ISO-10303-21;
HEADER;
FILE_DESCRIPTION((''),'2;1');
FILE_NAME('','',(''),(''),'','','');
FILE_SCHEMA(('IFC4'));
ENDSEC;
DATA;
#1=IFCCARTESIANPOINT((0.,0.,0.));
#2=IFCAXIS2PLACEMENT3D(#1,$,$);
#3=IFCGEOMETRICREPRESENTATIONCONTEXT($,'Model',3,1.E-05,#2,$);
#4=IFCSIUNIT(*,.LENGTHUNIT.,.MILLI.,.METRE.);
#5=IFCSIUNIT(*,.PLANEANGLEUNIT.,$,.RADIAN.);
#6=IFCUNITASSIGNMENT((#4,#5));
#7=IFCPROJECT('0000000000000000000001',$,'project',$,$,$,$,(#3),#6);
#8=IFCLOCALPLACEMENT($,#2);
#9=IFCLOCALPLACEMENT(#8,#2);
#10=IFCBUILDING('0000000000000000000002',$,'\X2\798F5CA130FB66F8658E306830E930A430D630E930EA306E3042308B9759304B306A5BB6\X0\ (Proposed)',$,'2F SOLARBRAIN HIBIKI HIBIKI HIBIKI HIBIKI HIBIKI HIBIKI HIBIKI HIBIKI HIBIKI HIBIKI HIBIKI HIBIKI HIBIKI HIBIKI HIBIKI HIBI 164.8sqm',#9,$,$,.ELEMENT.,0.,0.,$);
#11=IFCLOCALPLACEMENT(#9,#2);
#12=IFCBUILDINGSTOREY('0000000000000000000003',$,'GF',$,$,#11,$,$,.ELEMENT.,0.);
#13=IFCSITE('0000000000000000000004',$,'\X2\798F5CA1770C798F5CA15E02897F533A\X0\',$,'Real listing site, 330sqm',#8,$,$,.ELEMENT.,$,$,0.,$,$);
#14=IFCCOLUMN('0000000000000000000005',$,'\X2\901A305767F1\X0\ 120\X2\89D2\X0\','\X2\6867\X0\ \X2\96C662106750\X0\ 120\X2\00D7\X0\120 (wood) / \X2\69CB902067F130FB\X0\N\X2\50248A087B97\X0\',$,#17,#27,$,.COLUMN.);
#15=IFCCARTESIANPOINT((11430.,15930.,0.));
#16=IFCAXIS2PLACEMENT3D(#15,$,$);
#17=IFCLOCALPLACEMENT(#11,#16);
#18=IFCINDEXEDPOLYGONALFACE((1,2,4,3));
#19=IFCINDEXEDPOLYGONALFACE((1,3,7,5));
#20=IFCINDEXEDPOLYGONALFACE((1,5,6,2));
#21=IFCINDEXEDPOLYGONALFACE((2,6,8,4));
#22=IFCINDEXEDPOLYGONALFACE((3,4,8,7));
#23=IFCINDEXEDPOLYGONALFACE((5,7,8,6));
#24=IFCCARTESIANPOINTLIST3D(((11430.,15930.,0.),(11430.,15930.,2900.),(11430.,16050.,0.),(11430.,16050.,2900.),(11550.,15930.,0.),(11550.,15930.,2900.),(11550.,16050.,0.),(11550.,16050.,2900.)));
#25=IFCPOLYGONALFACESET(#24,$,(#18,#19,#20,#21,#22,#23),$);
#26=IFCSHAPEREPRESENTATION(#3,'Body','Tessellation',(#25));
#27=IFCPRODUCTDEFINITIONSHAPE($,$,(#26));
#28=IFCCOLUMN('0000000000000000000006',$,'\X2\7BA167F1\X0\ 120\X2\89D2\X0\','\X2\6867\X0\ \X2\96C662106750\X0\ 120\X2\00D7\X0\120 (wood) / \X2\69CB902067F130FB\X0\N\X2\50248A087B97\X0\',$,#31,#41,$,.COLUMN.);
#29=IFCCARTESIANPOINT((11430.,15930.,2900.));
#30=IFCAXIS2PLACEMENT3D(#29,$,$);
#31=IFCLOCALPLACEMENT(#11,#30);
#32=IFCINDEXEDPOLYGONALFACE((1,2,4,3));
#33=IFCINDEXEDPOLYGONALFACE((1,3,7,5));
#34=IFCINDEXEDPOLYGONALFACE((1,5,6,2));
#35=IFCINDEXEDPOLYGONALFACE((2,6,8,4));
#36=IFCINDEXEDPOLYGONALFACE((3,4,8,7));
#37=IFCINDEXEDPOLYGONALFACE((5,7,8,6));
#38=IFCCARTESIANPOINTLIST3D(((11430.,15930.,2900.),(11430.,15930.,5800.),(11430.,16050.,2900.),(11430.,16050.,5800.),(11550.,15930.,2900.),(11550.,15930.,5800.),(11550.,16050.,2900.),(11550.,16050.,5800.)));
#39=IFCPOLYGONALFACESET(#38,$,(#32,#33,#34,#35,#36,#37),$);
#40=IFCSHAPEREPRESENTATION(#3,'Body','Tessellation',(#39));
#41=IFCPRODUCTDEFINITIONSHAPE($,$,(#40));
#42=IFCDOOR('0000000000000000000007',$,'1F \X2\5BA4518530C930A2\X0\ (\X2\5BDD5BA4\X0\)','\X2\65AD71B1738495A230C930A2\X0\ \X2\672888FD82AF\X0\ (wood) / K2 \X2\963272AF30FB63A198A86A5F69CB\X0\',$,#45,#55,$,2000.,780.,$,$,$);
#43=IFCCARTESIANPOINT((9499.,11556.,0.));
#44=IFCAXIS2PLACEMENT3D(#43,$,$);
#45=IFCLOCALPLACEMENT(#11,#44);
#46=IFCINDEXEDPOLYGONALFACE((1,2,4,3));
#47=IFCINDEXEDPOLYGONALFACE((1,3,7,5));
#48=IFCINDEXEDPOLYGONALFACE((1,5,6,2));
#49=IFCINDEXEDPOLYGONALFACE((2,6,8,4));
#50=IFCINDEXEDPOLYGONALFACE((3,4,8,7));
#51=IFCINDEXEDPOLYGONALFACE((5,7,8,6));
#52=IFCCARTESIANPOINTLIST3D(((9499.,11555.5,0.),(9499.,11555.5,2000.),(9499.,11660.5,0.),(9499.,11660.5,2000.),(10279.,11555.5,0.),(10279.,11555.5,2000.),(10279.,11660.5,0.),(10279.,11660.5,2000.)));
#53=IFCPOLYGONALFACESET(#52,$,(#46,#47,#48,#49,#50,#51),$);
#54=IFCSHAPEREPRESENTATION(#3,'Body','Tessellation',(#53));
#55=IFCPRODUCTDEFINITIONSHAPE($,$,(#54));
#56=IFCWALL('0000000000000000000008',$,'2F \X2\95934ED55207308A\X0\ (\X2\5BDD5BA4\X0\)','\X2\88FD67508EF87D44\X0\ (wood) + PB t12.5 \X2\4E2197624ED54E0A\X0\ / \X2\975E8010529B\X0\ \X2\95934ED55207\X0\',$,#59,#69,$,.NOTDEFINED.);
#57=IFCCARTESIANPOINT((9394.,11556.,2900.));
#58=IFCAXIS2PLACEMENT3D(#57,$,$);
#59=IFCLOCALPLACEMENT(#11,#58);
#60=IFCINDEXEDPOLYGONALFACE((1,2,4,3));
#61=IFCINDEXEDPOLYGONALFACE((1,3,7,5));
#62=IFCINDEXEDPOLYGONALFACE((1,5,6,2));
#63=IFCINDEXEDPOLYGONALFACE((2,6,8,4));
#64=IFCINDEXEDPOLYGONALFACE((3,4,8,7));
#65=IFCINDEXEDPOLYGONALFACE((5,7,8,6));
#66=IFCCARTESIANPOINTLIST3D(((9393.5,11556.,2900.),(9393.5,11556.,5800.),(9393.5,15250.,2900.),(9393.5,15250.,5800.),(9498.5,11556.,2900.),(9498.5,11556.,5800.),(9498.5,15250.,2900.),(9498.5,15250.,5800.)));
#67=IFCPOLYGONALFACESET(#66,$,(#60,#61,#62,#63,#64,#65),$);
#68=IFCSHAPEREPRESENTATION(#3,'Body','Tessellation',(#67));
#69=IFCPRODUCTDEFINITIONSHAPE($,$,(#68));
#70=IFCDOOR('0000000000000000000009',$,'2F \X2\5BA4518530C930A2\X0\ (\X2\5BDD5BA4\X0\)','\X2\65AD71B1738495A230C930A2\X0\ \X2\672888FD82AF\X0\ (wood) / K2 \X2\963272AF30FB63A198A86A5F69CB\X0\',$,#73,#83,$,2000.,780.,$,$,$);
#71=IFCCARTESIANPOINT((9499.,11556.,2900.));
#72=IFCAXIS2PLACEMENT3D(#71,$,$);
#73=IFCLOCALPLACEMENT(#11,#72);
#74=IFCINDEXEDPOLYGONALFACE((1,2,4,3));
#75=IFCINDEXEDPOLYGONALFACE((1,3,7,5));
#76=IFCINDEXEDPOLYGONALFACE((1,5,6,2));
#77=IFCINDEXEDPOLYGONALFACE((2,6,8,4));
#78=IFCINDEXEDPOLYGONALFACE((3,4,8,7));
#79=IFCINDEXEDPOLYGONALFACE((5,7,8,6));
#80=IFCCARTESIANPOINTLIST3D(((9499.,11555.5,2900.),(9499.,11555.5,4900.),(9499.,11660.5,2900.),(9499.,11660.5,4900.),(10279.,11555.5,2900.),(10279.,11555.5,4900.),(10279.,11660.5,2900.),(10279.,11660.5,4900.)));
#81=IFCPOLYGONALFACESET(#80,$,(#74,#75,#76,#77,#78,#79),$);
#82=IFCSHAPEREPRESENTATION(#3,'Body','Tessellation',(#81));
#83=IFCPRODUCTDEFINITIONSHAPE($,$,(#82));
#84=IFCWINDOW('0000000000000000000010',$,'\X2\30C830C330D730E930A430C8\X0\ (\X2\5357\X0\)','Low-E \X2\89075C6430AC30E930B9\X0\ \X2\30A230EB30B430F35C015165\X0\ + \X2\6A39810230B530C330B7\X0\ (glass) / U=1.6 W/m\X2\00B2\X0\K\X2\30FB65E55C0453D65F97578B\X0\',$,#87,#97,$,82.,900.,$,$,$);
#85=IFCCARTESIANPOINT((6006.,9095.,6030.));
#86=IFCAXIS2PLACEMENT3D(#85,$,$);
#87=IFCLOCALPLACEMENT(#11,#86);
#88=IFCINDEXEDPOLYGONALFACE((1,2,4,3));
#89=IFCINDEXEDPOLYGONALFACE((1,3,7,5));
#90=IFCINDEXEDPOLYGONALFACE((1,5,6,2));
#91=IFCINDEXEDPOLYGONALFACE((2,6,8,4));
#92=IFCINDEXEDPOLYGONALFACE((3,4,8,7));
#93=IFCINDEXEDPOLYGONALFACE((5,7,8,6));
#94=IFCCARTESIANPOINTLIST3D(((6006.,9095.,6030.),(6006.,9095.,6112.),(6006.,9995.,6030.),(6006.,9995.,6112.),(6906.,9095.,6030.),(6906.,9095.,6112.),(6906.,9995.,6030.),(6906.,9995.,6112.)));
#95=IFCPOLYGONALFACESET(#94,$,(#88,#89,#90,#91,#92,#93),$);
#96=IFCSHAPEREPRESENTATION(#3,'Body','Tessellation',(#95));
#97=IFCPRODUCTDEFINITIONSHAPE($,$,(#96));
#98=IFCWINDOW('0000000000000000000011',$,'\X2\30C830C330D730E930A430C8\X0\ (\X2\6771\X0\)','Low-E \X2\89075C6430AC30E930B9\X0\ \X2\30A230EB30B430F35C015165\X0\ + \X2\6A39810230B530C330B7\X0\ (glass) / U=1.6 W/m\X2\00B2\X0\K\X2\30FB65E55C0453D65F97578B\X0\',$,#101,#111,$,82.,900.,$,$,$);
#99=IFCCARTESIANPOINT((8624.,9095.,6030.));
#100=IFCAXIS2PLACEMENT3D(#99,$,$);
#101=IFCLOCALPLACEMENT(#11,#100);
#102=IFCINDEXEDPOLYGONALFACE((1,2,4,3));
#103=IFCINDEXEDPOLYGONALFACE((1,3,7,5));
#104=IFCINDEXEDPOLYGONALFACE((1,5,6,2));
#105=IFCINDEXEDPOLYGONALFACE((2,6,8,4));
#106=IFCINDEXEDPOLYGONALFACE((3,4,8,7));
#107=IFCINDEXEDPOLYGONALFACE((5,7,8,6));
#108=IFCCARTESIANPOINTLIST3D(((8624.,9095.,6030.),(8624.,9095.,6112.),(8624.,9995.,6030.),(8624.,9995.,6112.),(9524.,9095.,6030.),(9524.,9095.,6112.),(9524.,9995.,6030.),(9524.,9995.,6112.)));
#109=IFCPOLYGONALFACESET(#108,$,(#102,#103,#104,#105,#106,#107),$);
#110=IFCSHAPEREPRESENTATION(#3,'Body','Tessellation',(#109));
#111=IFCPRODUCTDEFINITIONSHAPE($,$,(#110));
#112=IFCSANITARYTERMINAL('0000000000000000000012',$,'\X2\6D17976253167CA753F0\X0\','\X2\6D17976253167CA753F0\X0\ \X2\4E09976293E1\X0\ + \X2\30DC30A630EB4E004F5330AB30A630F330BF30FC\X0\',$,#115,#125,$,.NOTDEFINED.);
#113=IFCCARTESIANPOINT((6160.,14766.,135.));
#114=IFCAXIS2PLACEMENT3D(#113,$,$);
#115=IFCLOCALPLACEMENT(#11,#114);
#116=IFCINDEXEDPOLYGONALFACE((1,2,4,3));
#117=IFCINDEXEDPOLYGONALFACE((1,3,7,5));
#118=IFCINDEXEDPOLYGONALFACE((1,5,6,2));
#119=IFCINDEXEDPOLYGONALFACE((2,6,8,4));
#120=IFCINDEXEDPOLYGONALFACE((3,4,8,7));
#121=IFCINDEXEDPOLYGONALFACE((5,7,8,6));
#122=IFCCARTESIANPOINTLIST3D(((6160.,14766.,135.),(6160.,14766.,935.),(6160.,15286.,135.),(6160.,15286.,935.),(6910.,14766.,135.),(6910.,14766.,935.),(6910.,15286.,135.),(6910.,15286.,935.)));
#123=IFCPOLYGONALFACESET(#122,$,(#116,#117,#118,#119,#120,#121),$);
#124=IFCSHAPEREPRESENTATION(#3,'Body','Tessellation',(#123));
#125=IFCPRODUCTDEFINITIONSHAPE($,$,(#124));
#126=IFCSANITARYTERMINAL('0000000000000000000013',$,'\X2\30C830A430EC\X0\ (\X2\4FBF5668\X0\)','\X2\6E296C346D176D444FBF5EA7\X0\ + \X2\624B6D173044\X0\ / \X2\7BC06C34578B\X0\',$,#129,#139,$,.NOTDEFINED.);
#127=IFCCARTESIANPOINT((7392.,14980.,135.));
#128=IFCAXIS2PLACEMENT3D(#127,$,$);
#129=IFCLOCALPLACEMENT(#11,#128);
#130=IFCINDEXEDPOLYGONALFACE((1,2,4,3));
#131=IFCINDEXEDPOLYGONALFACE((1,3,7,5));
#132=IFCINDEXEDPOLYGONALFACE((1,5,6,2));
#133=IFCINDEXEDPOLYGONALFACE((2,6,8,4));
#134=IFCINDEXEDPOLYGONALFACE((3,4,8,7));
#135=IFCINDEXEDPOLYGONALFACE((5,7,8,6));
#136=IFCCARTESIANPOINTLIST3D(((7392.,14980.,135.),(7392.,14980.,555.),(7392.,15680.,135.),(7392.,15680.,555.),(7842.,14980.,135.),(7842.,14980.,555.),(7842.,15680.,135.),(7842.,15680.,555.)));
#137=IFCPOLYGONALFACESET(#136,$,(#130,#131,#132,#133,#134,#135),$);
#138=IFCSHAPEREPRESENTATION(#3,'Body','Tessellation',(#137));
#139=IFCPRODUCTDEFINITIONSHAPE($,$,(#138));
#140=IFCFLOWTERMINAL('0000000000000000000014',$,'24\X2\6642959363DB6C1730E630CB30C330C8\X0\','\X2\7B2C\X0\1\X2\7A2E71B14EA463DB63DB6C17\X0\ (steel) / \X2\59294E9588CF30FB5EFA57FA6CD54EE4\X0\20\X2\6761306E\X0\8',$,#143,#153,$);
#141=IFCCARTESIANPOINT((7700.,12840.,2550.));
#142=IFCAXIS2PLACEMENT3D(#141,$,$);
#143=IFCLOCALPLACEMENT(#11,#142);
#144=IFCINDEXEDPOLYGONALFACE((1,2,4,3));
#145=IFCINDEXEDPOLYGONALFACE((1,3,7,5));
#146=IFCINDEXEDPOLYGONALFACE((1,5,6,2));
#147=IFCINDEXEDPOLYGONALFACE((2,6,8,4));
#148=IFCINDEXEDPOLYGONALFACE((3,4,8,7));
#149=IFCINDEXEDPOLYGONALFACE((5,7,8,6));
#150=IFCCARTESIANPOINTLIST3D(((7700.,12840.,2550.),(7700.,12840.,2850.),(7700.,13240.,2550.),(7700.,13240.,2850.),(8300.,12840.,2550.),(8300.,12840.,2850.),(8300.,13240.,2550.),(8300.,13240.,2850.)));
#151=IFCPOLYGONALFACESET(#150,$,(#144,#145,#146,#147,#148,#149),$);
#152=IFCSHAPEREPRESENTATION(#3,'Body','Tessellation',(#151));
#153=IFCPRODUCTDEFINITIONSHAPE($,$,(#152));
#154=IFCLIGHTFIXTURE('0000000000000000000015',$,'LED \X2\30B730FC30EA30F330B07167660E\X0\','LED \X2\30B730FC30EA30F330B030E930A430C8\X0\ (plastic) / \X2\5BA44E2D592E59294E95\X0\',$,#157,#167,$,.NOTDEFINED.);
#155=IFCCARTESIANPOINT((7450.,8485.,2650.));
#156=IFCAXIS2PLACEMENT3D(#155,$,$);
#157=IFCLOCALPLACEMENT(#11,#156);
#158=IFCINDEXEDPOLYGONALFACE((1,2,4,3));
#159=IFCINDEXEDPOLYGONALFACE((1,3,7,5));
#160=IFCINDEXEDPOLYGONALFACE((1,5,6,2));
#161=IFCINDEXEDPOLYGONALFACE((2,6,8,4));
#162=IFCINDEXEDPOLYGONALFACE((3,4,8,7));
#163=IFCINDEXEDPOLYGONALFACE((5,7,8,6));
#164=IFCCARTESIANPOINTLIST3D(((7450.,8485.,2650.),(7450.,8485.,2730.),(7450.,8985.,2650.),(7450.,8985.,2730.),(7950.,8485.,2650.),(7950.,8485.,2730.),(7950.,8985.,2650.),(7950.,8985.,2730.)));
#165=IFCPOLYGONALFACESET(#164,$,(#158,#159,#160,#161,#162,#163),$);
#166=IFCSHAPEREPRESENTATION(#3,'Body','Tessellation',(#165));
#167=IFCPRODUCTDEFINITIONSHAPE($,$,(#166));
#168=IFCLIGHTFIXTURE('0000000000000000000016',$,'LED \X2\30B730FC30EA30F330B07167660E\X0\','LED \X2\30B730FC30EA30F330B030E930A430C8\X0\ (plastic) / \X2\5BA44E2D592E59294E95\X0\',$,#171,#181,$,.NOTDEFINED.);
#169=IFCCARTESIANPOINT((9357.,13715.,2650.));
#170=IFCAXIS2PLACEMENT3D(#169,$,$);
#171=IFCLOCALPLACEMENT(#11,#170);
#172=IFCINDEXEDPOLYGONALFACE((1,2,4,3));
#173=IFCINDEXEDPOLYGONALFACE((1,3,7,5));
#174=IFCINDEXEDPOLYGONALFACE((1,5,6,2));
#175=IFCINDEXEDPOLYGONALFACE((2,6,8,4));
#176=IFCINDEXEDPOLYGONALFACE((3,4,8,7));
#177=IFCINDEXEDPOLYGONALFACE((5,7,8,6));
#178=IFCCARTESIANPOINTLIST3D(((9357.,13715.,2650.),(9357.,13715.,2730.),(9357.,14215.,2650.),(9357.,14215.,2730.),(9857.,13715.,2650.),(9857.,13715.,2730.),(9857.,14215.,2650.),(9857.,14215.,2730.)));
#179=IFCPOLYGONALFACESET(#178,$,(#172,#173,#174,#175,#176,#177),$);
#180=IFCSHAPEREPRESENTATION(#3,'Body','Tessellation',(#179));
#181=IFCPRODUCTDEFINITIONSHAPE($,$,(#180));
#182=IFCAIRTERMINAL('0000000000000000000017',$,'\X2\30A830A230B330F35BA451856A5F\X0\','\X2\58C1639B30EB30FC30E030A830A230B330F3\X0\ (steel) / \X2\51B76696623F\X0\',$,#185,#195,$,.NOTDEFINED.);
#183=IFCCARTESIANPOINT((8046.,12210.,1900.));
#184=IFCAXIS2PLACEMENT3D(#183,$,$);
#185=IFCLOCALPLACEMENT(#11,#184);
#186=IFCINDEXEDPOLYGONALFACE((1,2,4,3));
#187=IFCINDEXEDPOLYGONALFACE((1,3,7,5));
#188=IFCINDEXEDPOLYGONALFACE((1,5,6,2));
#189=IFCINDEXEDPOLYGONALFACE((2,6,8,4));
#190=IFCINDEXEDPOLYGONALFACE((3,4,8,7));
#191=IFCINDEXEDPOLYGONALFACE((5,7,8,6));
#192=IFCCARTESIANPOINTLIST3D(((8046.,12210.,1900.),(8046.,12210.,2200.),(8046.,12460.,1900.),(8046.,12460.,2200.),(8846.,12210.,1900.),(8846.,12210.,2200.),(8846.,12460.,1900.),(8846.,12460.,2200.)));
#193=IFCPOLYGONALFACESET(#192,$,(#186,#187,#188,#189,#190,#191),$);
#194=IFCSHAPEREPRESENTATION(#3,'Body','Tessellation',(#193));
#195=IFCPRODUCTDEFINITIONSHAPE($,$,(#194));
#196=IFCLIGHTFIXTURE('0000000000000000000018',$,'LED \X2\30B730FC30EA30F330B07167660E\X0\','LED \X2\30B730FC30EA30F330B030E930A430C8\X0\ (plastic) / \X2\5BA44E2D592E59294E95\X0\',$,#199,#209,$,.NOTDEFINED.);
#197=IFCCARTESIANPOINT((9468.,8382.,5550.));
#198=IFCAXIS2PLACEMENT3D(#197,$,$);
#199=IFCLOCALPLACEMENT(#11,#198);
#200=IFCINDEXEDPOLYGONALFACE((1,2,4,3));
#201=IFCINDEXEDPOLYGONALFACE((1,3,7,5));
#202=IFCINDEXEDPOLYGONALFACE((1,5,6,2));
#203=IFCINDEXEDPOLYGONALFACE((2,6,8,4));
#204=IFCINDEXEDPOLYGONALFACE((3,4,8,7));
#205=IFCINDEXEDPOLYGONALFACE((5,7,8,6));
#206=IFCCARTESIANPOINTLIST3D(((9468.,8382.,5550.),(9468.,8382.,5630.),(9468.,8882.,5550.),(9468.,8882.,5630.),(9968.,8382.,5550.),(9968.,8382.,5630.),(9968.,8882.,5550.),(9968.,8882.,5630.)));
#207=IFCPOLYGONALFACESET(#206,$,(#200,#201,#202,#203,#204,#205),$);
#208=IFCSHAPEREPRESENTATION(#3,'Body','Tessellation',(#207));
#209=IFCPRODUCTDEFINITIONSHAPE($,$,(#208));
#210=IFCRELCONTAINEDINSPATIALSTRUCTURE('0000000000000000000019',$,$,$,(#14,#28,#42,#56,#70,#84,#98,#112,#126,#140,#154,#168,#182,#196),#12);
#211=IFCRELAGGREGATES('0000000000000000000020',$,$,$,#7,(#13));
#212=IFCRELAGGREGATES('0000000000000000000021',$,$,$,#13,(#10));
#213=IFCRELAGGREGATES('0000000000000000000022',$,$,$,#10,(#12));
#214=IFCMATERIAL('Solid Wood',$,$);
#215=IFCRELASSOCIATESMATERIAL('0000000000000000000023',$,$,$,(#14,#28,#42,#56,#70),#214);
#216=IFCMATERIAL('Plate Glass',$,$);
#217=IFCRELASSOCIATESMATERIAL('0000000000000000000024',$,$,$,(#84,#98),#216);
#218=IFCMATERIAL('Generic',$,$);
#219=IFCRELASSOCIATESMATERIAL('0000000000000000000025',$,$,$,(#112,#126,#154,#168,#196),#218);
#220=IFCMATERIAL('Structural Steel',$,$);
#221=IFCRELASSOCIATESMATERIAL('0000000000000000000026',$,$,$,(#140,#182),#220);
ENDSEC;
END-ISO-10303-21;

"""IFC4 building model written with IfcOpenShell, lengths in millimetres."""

from ifc_helpers import new_model, si_unit, frame, frame_2d, origin, place, context, project, spatial, rectangle, extrude, material, element, save


model = new_model("IFC4")

# Units and contexts
model_context = context("Model", 3, precision=1e-05, world=origin())
ifc_project = project(units=[si_unit("LENGTHUNIT", "METRE", prefix="MILLI"), si_unit("PLANEANGLEUNIT", "RADIAN")], contexts=[model_context])

# Site, building, storey
site_placement = place(None, origin())
site = spatial("IfcSite", under=ifc_project, at=site_placement, Name="福岡県福岡市西区", ObjectType="Real listing site, 330sqm", CompositionType="ELEMENT", RefElevation=0.0)
building_placement = place(site_placement, origin())
building = spatial("IfcBuilding", under=site, at=building_placement, Name="福岡・書斎とライブラリのある静かな家 (Proposed)", ObjectType="2F SOLARBRAIN HIBIKI HIBIKI HIBIKI HIBIKI HIBIKI HIBIKI HIBIKI HIBIKI HIBIKI HIBIKI HIBIKI HIBIKI HIBIKI HIBIKI HIBIKI HIBI 164.8sqm", CompositionType="ELEMENT", ElevationOfRefHeight=0.0, ElevationOfTerrain=0.0)
storey_placement = place(building_placement, origin())
storey = spatial("IfcBuildingStorey", under=building, at=storey_placement, Name="GF", CompositionType="ELEMENT", Elevation=0.0)

# Columns
ifc_material_1 = material(Name="Solid Wood")
column_1_placement = place(storey_placement, frame((11430.0, 15930.0, 0.0)))
element("IfcColumn", 1, at=column_1_placement, inside=storey, material=ifc_material_1, Name="通し柱 120角", Description="桧 集成材 120×120 (wood) / 構造柱・N値計算", PredefinedType="COLUMN", context=model_context, shape_type="SweptSolid", body=[
    extrude(rectangle(XDim=120.0, YDim=120.0, at=frame_2d((60.0, 60.0))), frame((11430.0, 15930.0, 0.0)), (0.0, 0.0, 1.0), 2900.0),
])
column_2_placement = place(storey_placement, frame((11430.0, 15930.0, 2900.0)))
element("IfcColumn", 2, at=column_2_placement, inside=storey, material=ifc_material_1, Name="管柱 120角", Description="桧 集成材 120×120 (wood) / 構造柱・N値計算", PredefinedType="COLUMN", context=model_context, shape_type="SweptSolid", body=[
    extrude(rectangle(XDim=120.0, YDim=120.0, at=frame_2d((60.0, 60.0))), frame((11430.0, 15930.0, 2900.0)), (0.0, 0.0, 1.0), 2900.0),
])

# Door
door_1_placement = place(storey_placement, frame((9499.0, 11556.0, 0.0)))
element("IfcDoor", 3, at=door_1_placement, inside=storey, material=ifc_material_1, Name="1F 室内ドア (寝室)", Description="断熱玄関ドア 木製芯 (wood) / K2 防犯・採風機構", OverallHeight=2000.0, OverallWidth=780.0, context=model_context, shape_type="SweptSolid", body=[
    extrude(rectangle(XDim=780.0, YDim=105.0, at=frame_2d((390.0, 52.0))), frame((9499.0, 11556.0, 0.0)), (0.0, 0.0, 1.0), 2000.0),
])

# Wall
wall_1_placement = place(storey_placement, frame((9394.0, 11556.0, 2900.0)))
element("IfcWall", 4, at=wall_1_placement, inside=storey, material=ifc_material_1, Name="2F 間仕切り (寝室)", Description="製材軸組 (wood) + PB t12.5 両面仕上 / 非耐力 間仕切", PredefinedType="NOTDEFINED", context=model_context, shape_type="SweptSolid", body=[
    extrude(rectangle(XDim=105.0, YDim=3694.0, at=frame_2d((52.0, 1847.0))), frame((9394.0, 11556.0, 2900.0)), (0.0, 0.0, 1.0), 2900.0),
])

# Door
door_2_placement = place(storey_placement, frame((9499.0, 11556.0, 2900.0)))
element("IfcDoor", 5, at=door_2_placement, inside=storey, material=ifc_material_1, Name="2F 室内ドア (寝室)", Description="断熱玄関ドア 木製芯 (wood) / K2 防犯・採風機構", OverallHeight=2000.0, OverallWidth=780.0, context=model_context, shape_type="SweptSolid", body=[
    extrude(rectangle(XDim=780.0, YDim=105.0, at=frame_2d((390.0, 52.0))), frame((9499.0, 11556.0, 2900.0)), (0.0, 0.0, 1.0), 2000.0),
])

# Windows
ifc_material_2 = material(Name="Plate Glass")
window_1_placement = place(storey_placement, frame((6006.0, 9095.0, 6030.0)))
element("IfcWindow", 6, at=window_1_placement, inside=storey, material=ifc_material_2, Name="トップライト (南)", Description="Low-E 複層ガラス アルゴン封入 + 樹脂サッシ (glass) / U=1.6 W/m²K・日射取得型", OverallHeight=82.0, OverallWidth=900.0, context=model_context, shape_type="SweptSolid", body=[
    extrude(rectangle(XDim=900.0, YDim=900.0, at=frame_2d((450.0, 450.0))), frame((6006.0, 9095.0, 6030.0)), (0.0, 0.0, 1.0), 82.0),
])
window_2_placement = place(storey_placement, frame((8624.0, 9095.0, 6030.0)))
element("IfcWindow", 7, at=window_2_placement, inside=storey, material=ifc_material_2, Name="トップライト (東)", Description="Low-E 複層ガラス アルゴン封入 + 樹脂サッシ (glass) / U=1.6 W/m²K・日射取得型", OverallHeight=82.0, OverallWidth=900.0, context=model_context, shape_type="SweptSolid", body=[
    extrude(rectangle(XDim=900.0, YDim=900.0, at=frame_2d((450.0, 450.0))), frame((8624.0, 9095.0, 6030.0)), (0.0, 0.0, 1.0), 82.0),
])

# Sanitary terminals
ifc_material_3 = material(Name="Generic")
sanitary_terminal_1_placement = place(storey_placement, frame((6160.0, 14766.0, 135.0)))
element("IfcSanitaryTerminal", 8, at=sanitary_terminal_1_placement, inside=storey, material=ifc_material_3, Name="洗面化粧台", Description="洗面化粧台 三面鏡 + ボウル一体カウンター", PredefinedType="NOTDEFINED", context=model_context, shape_type="SweptSolid", body=[
    extrude(rectangle(XDim=750.0, YDim=520.0, at=frame_2d((375.0, 260.0))), frame((6160.0, 14766.0, 135.0)), (0.0, 0.0, 1.0), 800.0),
])
sanitary_terminal_2_placement = place(storey_placement, frame((7392.0, 14980.0, 135.0)))
element("IfcSanitaryTerminal", 9, at=sanitary_terminal_2_placement, inside=storey, material=ifc_material_3, Name="トイレ (便器)", Description="温水洗浄便座 + 手洗い / 節水型", PredefinedType="NOTDEFINED", context=model_context, shape_type="SweptSolid", body=[
    extrude(rectangle(XDim=450.0, YDim=700.0, at=frame_2d((225.0, 350.0))), frame((7392.0, 14980.0, 135.0)), (0.0, 0.0, 1.0), 420.0),
])

# Flow terminal
ifc_material_4 = material(Name="Structural Steel")
flow_terminal_placement = place(storey_placement, frame((7700.0, 12840.0, 2550.0)))
element("IfcFlowTerminal", 10, at=flow_terminal_placement, inside=storey, material=ifc_material_4, Name="24時間換気ユニット", Description="第1種熱交換換気 (steel) / 天井裏・建基法令20条の8", context=model_context, shape_type="SweptSolid", body=[
    extrude(rectangle(XDim=600.0, YDim=400.0, at=frame_2d((300.0, 200.0))), frame((7700.0, 12840.0, 2550.0)), (0.0, 0.0, 1.0), 300.0),
])

# Light fixtures
light_fixture_1_placement = place(storey_placement, frame((7450.0, 8485.0, 2650.0)))
element("IfcLightFixture", 11, at=light_fixture_1_placement, inside=storey, material=ifc_material_3, Name="LED シーリング照明", Description="LED シーリングライト (plastic) / 室中央天井", PredefinedType="NOTDEFINED", context=model_context, shape_type="SweptSolid", body=[
    extrude(rectangle(XDim=500.0, YDim=500.0, at=frame_2d((250.0, 250.0))), frame((7450.0, 8485.0, 2650.0)), (0.0, 0.0, 1.0), 80.0),
])
light_fixture_2_placement = place(storey_placement, frame((9357.0, 13715.0, 2650.0)))
element("IfcLightFixture", 12, at=light_fixture_2_placement, inside=storey, material=ifc_material_3, Name="LED シーリング照明", Description="LED シーリングライト (plastic) / 室中央天井", PredefinedType="NOTDEFINED", context=model_context, shape_type="SweptSolid", body=[
    extrude(rectangle(XDim=500.0, YDim=500.0, at=frame_2d((250.0, 250.0))), frame((9357.0, 13715.0, 2650.0)), (0.0, 0.0, 1.0), 80.0),
])

# Air terminal
air_terminal_placement = place(storey_placement, frame((8046.0, 12210.0, 1900.0)))
element("IfcAirTerminal", 13, at=air_terminal_placement, inside=storey, material=ifc_material_4, Name="エアコン室内機", Description="壁掛ルームエアコン (steel) / 冷暖房", PredefinedType="NOTDEFINED", context=model_context, shape_type="SweptSolid", body=[
    extrude(rectangle(XDim=800.0, YDim=250.0, at=frame_2d((400.0, 125.0))), frame((8046.0, 12210.0, 1900.0)), (0.0, 0.0, 1.0), 300.0),
])

# Light fixture
light_fixture_3_placement = place(storey_placement, frame((9468.0, 8382.0, 5550.0)))
element("IfcLightFixture", 14, at=light_fixture_3_placement, inside=storey, material=ifc_material_3, Name="LED シーリング照明", Description="LED シーリングライト (plastic) / 室中央天井", PredefinedType="NOTDEFINED", context=model_context, shape_type="SweptSolid", body=[
    extrude(rectangle(XDim=500.0, YDim=500.0, at=frame_2d((250.0, 250.0))), frame((9468.0, 8382.0, 5550.0)), (0.0, 0.0, 1.0), 80.0),
])

save(model, "model.ifc")
